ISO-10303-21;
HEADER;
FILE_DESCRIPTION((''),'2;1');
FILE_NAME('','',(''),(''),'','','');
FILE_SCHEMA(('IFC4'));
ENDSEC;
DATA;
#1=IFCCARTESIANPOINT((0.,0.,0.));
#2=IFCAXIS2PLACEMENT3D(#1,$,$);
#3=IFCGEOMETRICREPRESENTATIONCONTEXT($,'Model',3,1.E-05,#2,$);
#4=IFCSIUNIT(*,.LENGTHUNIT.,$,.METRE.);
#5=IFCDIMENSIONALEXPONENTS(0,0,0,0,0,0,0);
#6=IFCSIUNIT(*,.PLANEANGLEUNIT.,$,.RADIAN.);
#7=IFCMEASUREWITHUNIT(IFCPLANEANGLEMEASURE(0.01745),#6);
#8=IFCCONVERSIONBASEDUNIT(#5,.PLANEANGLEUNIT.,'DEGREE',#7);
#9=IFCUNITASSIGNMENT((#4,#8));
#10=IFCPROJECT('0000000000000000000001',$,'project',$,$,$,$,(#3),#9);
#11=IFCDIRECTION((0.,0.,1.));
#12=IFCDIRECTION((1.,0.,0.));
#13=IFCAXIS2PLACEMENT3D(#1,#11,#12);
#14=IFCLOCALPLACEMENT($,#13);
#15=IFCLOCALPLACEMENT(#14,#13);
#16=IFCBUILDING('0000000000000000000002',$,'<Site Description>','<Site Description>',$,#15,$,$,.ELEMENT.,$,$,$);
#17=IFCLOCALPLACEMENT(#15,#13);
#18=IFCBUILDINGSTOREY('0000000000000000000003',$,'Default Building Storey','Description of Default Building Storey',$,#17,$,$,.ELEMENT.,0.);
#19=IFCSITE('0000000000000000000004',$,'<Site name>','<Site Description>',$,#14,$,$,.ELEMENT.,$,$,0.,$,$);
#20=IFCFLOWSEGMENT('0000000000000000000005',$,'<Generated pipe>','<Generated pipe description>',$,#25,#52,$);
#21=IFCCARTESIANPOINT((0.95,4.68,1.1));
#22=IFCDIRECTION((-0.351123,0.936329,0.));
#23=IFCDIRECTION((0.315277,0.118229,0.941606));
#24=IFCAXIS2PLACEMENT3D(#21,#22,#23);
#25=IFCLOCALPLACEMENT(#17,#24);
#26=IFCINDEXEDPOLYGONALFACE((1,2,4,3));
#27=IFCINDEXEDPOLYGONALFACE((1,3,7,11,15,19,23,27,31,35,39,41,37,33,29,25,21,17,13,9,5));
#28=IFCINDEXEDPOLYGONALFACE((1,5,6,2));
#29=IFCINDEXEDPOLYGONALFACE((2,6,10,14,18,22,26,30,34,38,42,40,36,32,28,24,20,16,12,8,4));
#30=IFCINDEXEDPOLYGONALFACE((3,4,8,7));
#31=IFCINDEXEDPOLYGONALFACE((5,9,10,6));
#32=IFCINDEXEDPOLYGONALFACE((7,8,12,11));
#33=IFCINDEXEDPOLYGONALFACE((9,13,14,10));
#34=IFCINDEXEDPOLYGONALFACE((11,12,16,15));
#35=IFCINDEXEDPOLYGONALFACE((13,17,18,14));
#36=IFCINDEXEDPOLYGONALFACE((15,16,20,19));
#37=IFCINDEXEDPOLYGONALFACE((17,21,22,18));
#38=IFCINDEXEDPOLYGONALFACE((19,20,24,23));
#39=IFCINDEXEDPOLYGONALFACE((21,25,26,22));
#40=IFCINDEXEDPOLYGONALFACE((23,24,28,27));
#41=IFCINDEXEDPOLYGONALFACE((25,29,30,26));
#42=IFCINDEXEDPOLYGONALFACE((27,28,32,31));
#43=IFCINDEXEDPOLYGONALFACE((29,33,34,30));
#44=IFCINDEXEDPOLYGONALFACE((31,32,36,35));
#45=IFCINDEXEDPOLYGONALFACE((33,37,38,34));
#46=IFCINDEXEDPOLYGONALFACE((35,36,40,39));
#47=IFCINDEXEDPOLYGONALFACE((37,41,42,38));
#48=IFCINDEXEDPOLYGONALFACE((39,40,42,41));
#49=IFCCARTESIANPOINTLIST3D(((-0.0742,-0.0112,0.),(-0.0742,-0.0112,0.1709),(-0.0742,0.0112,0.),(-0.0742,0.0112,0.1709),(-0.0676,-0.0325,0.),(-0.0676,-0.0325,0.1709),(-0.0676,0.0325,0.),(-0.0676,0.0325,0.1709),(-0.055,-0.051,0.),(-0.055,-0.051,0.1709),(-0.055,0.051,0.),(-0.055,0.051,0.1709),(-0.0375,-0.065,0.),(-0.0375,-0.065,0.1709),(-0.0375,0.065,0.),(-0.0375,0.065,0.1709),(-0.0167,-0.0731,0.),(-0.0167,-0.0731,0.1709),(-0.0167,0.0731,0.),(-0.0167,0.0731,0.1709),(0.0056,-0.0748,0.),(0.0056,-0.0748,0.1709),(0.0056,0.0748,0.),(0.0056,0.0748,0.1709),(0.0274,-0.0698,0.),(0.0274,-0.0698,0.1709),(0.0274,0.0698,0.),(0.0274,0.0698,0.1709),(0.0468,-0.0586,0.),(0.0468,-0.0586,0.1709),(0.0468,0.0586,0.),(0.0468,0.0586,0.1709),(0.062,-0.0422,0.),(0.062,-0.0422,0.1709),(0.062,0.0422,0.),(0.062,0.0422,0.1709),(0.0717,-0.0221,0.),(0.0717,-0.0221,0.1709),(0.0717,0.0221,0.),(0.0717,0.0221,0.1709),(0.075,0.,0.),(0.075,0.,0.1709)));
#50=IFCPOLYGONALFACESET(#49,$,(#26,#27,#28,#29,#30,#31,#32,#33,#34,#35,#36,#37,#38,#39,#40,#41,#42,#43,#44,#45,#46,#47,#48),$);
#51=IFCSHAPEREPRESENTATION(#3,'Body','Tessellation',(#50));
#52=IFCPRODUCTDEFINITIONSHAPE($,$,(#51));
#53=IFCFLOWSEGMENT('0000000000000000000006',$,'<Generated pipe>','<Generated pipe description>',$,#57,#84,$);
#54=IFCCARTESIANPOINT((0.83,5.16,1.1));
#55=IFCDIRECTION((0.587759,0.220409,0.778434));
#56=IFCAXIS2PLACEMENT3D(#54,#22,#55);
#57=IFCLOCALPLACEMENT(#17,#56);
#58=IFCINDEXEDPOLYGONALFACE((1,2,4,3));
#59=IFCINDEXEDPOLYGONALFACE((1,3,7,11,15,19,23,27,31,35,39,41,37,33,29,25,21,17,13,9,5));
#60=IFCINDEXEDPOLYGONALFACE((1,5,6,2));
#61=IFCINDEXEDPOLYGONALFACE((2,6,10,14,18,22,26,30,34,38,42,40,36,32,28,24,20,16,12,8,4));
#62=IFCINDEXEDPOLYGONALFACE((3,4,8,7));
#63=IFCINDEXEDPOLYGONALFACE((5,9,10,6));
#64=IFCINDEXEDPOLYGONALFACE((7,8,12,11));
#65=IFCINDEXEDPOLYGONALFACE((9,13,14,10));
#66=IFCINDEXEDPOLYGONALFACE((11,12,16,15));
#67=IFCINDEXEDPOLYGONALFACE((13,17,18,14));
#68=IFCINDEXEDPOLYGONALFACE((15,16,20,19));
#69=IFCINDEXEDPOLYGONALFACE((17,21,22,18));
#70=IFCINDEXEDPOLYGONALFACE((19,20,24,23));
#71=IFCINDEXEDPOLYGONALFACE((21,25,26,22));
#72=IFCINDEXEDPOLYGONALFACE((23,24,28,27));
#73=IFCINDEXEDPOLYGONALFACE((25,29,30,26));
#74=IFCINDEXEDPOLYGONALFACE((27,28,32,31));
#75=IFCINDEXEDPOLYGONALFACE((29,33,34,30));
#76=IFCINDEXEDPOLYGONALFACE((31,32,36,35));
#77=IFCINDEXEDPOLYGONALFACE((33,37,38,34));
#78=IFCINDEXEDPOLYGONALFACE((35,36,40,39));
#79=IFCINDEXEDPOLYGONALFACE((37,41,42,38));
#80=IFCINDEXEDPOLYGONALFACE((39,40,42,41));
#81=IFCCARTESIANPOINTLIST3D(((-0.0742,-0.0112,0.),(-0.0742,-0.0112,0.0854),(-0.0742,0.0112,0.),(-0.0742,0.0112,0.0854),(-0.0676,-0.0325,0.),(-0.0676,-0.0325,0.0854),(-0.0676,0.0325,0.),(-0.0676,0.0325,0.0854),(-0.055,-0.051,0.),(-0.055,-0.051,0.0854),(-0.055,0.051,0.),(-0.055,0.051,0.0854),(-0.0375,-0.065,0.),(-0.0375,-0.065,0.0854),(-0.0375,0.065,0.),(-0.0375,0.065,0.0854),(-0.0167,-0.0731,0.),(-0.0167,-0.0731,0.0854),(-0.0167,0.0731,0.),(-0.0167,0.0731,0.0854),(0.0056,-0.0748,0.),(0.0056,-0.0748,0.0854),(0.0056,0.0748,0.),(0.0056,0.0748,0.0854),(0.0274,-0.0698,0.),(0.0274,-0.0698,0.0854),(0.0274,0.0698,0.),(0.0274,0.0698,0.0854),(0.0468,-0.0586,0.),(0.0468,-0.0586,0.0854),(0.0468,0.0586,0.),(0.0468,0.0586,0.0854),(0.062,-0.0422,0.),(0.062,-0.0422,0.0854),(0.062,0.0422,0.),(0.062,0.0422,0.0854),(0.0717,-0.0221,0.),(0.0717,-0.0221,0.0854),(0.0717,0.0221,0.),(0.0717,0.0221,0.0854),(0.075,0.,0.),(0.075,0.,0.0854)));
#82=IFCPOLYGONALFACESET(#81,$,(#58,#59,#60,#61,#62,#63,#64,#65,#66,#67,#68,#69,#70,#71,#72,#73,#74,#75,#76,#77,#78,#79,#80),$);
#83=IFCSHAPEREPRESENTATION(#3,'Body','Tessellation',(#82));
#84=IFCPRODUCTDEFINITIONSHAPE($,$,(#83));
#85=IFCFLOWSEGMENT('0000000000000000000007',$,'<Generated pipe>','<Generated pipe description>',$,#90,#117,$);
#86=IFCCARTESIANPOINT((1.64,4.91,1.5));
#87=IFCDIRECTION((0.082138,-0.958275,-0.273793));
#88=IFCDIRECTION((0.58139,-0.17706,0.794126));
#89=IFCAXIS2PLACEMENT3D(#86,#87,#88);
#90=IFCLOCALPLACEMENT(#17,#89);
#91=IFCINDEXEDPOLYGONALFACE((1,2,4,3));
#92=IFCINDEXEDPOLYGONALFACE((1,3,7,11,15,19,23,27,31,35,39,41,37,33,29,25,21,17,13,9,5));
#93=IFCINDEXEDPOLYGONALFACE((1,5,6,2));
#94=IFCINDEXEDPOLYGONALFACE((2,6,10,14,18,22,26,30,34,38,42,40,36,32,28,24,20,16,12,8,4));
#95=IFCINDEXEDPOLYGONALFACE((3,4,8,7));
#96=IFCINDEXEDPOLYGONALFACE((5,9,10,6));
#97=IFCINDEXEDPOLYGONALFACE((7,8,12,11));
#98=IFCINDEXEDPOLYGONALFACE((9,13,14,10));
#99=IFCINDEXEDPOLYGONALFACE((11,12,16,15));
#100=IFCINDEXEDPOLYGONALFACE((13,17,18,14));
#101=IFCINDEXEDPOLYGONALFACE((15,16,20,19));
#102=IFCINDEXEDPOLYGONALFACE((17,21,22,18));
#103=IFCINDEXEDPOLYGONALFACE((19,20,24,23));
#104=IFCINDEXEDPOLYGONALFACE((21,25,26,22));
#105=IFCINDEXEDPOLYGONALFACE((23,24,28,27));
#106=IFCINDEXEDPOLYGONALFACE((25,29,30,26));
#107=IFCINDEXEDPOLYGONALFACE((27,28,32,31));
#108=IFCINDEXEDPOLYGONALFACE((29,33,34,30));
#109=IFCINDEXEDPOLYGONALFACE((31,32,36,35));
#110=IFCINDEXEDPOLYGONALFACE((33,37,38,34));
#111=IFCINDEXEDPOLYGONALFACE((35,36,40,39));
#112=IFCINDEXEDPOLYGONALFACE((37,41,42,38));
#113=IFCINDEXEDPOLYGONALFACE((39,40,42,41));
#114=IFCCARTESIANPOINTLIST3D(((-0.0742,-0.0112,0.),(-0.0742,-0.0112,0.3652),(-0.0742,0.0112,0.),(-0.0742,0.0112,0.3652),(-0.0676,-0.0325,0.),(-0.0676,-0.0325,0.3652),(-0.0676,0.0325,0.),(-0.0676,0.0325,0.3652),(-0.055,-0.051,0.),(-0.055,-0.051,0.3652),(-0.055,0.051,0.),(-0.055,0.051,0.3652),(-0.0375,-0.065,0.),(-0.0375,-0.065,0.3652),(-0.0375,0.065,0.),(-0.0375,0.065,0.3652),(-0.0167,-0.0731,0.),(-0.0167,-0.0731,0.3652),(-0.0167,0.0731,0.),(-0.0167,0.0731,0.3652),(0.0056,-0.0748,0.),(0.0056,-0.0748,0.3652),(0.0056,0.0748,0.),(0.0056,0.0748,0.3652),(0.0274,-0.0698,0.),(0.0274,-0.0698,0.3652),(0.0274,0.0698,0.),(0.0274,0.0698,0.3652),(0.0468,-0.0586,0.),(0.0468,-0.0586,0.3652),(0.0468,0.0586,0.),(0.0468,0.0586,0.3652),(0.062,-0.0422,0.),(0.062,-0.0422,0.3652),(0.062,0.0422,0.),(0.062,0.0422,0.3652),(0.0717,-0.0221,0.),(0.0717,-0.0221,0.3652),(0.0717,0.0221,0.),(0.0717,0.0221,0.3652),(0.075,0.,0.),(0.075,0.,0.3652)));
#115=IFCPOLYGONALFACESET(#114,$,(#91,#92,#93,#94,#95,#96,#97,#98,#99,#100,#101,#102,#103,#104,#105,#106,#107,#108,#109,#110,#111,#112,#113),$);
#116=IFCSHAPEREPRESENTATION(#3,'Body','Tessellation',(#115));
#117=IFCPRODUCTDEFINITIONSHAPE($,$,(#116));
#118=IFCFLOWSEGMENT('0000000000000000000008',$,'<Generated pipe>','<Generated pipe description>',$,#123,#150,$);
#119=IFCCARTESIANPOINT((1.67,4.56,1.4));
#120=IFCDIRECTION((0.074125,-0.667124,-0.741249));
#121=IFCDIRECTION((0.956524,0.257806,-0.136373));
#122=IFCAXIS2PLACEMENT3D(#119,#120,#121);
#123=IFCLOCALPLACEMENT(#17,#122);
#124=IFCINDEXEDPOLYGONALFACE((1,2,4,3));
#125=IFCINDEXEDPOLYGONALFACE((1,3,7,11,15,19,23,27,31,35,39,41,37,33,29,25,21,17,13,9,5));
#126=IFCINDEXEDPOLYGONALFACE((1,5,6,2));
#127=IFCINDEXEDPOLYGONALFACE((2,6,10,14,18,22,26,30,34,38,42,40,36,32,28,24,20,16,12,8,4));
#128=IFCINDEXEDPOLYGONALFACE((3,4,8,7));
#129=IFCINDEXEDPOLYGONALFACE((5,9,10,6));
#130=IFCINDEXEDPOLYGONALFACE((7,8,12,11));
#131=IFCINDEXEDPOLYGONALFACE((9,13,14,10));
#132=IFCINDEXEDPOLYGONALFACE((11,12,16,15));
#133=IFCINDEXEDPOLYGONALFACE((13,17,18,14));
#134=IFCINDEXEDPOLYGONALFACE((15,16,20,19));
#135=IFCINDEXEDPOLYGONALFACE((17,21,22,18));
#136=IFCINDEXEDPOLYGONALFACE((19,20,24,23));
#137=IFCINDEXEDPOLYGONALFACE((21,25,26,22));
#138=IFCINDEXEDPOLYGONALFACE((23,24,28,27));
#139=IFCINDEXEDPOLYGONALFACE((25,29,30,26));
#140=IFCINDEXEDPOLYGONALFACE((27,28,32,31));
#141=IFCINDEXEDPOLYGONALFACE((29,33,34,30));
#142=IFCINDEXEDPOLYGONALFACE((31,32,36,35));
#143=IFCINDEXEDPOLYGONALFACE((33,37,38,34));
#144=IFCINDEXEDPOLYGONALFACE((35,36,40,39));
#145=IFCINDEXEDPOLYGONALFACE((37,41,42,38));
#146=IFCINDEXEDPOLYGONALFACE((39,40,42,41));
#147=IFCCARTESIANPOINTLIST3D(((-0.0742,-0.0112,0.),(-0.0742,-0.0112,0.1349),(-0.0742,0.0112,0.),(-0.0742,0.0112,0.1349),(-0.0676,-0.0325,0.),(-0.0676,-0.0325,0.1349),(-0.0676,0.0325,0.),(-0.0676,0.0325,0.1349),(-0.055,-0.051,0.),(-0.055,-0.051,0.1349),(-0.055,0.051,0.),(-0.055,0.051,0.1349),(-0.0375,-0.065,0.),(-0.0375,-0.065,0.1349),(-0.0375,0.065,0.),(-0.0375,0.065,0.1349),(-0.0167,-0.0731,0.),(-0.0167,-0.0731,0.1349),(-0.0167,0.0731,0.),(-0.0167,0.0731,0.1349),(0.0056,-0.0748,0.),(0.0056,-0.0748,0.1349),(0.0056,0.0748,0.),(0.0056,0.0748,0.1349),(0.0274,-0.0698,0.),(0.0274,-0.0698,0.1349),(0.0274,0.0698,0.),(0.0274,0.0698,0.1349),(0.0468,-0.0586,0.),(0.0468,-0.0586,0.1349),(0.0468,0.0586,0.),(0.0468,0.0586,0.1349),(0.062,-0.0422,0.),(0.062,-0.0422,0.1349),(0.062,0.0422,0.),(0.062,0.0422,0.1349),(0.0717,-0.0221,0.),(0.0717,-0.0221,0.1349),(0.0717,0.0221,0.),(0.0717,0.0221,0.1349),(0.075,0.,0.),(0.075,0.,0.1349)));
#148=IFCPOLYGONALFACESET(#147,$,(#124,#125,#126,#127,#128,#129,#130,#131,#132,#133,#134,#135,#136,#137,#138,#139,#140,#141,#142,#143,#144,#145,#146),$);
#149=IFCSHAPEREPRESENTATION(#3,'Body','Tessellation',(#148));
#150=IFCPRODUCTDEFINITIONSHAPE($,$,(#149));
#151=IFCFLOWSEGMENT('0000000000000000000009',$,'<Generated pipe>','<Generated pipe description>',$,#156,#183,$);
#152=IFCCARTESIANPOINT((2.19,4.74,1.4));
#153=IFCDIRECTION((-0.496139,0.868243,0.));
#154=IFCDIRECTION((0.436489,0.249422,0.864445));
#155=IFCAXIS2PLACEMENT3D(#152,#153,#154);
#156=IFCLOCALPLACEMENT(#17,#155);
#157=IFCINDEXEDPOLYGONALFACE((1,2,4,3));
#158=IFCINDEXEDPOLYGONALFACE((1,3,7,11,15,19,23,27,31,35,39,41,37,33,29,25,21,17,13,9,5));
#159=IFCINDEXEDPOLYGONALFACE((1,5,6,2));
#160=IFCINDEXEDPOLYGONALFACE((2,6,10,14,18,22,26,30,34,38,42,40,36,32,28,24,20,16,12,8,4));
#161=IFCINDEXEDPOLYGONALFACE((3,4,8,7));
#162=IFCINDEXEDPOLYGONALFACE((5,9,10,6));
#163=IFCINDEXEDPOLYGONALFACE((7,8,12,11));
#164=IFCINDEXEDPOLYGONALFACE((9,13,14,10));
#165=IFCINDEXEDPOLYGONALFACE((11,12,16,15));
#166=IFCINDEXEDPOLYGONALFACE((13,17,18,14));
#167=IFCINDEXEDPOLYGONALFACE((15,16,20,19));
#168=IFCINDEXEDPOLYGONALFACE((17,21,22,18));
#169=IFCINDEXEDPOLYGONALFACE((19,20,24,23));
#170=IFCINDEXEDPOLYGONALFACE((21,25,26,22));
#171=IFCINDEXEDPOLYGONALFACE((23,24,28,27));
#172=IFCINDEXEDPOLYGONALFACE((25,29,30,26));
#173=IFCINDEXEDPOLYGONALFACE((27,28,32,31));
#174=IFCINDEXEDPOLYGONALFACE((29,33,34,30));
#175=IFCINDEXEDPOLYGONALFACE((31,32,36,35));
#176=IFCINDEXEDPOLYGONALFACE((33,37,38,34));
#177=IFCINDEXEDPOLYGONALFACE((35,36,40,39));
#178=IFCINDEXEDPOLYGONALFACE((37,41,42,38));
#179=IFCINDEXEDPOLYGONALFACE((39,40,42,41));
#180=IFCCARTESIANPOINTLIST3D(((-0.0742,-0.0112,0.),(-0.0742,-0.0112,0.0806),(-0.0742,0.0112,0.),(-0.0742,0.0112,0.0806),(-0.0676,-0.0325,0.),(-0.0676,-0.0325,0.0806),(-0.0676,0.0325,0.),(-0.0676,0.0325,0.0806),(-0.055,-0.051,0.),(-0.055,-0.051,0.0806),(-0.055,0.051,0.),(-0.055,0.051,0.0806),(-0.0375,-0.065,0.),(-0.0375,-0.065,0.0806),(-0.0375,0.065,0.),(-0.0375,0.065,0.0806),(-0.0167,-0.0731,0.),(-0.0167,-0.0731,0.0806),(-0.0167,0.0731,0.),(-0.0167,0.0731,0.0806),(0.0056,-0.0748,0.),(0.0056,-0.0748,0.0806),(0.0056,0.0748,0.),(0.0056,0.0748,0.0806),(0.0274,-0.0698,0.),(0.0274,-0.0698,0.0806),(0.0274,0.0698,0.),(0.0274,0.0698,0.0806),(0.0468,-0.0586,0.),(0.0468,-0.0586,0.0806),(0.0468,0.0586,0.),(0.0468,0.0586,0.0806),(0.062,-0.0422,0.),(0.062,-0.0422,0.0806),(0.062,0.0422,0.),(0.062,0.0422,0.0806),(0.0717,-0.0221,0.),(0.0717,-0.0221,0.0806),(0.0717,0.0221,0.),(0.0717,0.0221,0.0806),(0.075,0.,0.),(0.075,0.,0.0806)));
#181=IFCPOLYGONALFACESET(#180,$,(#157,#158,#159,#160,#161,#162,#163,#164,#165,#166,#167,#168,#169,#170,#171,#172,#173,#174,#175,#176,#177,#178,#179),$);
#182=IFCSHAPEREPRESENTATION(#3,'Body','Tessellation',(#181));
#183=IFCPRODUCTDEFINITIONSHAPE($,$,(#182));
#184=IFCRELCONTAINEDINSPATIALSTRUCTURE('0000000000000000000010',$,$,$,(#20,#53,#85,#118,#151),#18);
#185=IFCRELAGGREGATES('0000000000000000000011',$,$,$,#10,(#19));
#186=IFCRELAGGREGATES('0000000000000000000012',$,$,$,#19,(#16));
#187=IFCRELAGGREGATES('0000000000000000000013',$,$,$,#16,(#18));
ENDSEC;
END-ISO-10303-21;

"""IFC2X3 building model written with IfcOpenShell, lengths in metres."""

from ifc_helpers import new_model, entity, si_unit, converted_unit, frame, origin, origin_with_axes, origin_2d_with_axis, place, context, project, spatial, circle, extrude, element, save


model = new_model("IFC2X3")

# Units and contexts
model_context = context("Model", 3, precision=1e-05, world=origin())
ifc_project = project(units=[si_unit("LENGTHUNIT", "METRE"), converted_unit("PLANEANGLEUNIT", "DEGREE", entity("IfcPlaneAngleMeasure", 0.01745), si_unit("PLANEANGLEUNIT", "RADIAN"), dimensions=[0, 0, 0, 0, 0, 0, 0])], contexts=[model_context])

# Site, building, storey
site_placement = place(None, origin_with_axes())
site = spatial("IfcSite", under=ifc_project, at=site_placement, Name="<Site name>", Description="<Site Description>", CompositionType="ELEMENT", RefElevation=0.0)
building_placement = place(site_placement, origin_with_axes())
building = spatial("IfcBuilding", under=site, at=building_placement, Name="<Site Description>", Description="<Site Description>", CompositionType="ELEMENT")
storey_placement = place(building_placement, origin_with_axes())
storey = spatial("IfcBuildingStorey", under=building, at=storey_placement, Name="Default Building Storey", Description="Description of Default Building Storey", CompositionType="ELEMENT", Elevation=0.0)

# Flow segments
flow_segment_1_placement = place(storey_placement, frame((0.95, 4.68, 1.1), z_axis=(-0.351123, 0.936329, 0.0), x_axis=(0.315277, 0.118229, 0.941606)))
element("IfcFlowSegment", 1, at=flow_segment_1_placement, inside=storey, Name="<Generated pipe>", Description="<Generated pipe description>", context=model_context, shape_type="SweptSolid", body=[
    extrude(circle(Radius=0.075, at=origin_2d_with_axis()), origin_with_axes(), (0.0, 0.0, 1.0), 0.1709),
])
flow_segment_2_placement = place(storey_placement, frame((0.83, 5.16, 1.1), z_axis=(-0.351123, 0.936329, 0.0), x_axis=(0.587759, 0.220409, 0.778434)))
element("IfcFlowSegment", 2, at=flow_segment_2_placement, inside=storey, Name="<Generated pipe>", Description="<Generated pipe description>", context=model_context, shape_type="SweptSolid", body=[
    extrude(circle(Radius=0.075, at=origin_2d_with_axis()), origin_with_axes(), (0.0, 0.0, 1.0), 0.0854),
])
flow_segment_3_placement = place(storey_placement, frame((1.64, 4.91, 1.5), z_axis=(0.082138, -0.958275, -0.273793), x_axis=(0.58139, -0.17706, 0.794126)))
element("IfcFlowSegment", 3, at=flow_segment_3_placement, inside=storey, Name="<Generated pipe>", Description="<Generated pipe description>", context=model_context, shape_type="SweptSolid", body=[
    extrude(circle(Radius=0.075, at=origin_2d_with_axis()), origin_with_axes(), (0.0, 0.0, 1.0), 0.3652),
])
flow_segment_4_placement = place(storey_placement, frame((1.67, 4.56, 1.4), z_axis=(0.074125, -0.667124, -0.741249), x_axis=(0.956524, 0.257806, -0.136373)))
element("IfcFlowSegment", 4, at=flow_segment_4_placement, inside=storey, Name="<Generated pipe>", Description="<Generated pipe description>", context=model_context, shape_type="SweptSolid", body=[
    extrude(circle(Radius=0.075, at=origin_2d_with_axis()), origin_with_axes(), (0.0, 0.0, 1.0), 0.1349),
])
flow_segment_5_placement = place(storey_placement, frame((2.19, 4.74, 1.4), z_axis=(-0.496139, 0.868243, 0.0), x_axis=(0.436489, 0.249422, 0.864445)))
element("IfcFlowSegment", 5, at=flow_segment_5_placement, inside=storey, Name="<Generated pipe>", Description="<Generated pipe description>", context=model_context, shape_type="SweptSolid", body=[
    extrude(circle(Radius=0.075, at=origin_2d_with_axis()), origin_with_axes(), (0.0, 0.0, 1.0), 0.0806),
])

save(model, "model.ifc")
